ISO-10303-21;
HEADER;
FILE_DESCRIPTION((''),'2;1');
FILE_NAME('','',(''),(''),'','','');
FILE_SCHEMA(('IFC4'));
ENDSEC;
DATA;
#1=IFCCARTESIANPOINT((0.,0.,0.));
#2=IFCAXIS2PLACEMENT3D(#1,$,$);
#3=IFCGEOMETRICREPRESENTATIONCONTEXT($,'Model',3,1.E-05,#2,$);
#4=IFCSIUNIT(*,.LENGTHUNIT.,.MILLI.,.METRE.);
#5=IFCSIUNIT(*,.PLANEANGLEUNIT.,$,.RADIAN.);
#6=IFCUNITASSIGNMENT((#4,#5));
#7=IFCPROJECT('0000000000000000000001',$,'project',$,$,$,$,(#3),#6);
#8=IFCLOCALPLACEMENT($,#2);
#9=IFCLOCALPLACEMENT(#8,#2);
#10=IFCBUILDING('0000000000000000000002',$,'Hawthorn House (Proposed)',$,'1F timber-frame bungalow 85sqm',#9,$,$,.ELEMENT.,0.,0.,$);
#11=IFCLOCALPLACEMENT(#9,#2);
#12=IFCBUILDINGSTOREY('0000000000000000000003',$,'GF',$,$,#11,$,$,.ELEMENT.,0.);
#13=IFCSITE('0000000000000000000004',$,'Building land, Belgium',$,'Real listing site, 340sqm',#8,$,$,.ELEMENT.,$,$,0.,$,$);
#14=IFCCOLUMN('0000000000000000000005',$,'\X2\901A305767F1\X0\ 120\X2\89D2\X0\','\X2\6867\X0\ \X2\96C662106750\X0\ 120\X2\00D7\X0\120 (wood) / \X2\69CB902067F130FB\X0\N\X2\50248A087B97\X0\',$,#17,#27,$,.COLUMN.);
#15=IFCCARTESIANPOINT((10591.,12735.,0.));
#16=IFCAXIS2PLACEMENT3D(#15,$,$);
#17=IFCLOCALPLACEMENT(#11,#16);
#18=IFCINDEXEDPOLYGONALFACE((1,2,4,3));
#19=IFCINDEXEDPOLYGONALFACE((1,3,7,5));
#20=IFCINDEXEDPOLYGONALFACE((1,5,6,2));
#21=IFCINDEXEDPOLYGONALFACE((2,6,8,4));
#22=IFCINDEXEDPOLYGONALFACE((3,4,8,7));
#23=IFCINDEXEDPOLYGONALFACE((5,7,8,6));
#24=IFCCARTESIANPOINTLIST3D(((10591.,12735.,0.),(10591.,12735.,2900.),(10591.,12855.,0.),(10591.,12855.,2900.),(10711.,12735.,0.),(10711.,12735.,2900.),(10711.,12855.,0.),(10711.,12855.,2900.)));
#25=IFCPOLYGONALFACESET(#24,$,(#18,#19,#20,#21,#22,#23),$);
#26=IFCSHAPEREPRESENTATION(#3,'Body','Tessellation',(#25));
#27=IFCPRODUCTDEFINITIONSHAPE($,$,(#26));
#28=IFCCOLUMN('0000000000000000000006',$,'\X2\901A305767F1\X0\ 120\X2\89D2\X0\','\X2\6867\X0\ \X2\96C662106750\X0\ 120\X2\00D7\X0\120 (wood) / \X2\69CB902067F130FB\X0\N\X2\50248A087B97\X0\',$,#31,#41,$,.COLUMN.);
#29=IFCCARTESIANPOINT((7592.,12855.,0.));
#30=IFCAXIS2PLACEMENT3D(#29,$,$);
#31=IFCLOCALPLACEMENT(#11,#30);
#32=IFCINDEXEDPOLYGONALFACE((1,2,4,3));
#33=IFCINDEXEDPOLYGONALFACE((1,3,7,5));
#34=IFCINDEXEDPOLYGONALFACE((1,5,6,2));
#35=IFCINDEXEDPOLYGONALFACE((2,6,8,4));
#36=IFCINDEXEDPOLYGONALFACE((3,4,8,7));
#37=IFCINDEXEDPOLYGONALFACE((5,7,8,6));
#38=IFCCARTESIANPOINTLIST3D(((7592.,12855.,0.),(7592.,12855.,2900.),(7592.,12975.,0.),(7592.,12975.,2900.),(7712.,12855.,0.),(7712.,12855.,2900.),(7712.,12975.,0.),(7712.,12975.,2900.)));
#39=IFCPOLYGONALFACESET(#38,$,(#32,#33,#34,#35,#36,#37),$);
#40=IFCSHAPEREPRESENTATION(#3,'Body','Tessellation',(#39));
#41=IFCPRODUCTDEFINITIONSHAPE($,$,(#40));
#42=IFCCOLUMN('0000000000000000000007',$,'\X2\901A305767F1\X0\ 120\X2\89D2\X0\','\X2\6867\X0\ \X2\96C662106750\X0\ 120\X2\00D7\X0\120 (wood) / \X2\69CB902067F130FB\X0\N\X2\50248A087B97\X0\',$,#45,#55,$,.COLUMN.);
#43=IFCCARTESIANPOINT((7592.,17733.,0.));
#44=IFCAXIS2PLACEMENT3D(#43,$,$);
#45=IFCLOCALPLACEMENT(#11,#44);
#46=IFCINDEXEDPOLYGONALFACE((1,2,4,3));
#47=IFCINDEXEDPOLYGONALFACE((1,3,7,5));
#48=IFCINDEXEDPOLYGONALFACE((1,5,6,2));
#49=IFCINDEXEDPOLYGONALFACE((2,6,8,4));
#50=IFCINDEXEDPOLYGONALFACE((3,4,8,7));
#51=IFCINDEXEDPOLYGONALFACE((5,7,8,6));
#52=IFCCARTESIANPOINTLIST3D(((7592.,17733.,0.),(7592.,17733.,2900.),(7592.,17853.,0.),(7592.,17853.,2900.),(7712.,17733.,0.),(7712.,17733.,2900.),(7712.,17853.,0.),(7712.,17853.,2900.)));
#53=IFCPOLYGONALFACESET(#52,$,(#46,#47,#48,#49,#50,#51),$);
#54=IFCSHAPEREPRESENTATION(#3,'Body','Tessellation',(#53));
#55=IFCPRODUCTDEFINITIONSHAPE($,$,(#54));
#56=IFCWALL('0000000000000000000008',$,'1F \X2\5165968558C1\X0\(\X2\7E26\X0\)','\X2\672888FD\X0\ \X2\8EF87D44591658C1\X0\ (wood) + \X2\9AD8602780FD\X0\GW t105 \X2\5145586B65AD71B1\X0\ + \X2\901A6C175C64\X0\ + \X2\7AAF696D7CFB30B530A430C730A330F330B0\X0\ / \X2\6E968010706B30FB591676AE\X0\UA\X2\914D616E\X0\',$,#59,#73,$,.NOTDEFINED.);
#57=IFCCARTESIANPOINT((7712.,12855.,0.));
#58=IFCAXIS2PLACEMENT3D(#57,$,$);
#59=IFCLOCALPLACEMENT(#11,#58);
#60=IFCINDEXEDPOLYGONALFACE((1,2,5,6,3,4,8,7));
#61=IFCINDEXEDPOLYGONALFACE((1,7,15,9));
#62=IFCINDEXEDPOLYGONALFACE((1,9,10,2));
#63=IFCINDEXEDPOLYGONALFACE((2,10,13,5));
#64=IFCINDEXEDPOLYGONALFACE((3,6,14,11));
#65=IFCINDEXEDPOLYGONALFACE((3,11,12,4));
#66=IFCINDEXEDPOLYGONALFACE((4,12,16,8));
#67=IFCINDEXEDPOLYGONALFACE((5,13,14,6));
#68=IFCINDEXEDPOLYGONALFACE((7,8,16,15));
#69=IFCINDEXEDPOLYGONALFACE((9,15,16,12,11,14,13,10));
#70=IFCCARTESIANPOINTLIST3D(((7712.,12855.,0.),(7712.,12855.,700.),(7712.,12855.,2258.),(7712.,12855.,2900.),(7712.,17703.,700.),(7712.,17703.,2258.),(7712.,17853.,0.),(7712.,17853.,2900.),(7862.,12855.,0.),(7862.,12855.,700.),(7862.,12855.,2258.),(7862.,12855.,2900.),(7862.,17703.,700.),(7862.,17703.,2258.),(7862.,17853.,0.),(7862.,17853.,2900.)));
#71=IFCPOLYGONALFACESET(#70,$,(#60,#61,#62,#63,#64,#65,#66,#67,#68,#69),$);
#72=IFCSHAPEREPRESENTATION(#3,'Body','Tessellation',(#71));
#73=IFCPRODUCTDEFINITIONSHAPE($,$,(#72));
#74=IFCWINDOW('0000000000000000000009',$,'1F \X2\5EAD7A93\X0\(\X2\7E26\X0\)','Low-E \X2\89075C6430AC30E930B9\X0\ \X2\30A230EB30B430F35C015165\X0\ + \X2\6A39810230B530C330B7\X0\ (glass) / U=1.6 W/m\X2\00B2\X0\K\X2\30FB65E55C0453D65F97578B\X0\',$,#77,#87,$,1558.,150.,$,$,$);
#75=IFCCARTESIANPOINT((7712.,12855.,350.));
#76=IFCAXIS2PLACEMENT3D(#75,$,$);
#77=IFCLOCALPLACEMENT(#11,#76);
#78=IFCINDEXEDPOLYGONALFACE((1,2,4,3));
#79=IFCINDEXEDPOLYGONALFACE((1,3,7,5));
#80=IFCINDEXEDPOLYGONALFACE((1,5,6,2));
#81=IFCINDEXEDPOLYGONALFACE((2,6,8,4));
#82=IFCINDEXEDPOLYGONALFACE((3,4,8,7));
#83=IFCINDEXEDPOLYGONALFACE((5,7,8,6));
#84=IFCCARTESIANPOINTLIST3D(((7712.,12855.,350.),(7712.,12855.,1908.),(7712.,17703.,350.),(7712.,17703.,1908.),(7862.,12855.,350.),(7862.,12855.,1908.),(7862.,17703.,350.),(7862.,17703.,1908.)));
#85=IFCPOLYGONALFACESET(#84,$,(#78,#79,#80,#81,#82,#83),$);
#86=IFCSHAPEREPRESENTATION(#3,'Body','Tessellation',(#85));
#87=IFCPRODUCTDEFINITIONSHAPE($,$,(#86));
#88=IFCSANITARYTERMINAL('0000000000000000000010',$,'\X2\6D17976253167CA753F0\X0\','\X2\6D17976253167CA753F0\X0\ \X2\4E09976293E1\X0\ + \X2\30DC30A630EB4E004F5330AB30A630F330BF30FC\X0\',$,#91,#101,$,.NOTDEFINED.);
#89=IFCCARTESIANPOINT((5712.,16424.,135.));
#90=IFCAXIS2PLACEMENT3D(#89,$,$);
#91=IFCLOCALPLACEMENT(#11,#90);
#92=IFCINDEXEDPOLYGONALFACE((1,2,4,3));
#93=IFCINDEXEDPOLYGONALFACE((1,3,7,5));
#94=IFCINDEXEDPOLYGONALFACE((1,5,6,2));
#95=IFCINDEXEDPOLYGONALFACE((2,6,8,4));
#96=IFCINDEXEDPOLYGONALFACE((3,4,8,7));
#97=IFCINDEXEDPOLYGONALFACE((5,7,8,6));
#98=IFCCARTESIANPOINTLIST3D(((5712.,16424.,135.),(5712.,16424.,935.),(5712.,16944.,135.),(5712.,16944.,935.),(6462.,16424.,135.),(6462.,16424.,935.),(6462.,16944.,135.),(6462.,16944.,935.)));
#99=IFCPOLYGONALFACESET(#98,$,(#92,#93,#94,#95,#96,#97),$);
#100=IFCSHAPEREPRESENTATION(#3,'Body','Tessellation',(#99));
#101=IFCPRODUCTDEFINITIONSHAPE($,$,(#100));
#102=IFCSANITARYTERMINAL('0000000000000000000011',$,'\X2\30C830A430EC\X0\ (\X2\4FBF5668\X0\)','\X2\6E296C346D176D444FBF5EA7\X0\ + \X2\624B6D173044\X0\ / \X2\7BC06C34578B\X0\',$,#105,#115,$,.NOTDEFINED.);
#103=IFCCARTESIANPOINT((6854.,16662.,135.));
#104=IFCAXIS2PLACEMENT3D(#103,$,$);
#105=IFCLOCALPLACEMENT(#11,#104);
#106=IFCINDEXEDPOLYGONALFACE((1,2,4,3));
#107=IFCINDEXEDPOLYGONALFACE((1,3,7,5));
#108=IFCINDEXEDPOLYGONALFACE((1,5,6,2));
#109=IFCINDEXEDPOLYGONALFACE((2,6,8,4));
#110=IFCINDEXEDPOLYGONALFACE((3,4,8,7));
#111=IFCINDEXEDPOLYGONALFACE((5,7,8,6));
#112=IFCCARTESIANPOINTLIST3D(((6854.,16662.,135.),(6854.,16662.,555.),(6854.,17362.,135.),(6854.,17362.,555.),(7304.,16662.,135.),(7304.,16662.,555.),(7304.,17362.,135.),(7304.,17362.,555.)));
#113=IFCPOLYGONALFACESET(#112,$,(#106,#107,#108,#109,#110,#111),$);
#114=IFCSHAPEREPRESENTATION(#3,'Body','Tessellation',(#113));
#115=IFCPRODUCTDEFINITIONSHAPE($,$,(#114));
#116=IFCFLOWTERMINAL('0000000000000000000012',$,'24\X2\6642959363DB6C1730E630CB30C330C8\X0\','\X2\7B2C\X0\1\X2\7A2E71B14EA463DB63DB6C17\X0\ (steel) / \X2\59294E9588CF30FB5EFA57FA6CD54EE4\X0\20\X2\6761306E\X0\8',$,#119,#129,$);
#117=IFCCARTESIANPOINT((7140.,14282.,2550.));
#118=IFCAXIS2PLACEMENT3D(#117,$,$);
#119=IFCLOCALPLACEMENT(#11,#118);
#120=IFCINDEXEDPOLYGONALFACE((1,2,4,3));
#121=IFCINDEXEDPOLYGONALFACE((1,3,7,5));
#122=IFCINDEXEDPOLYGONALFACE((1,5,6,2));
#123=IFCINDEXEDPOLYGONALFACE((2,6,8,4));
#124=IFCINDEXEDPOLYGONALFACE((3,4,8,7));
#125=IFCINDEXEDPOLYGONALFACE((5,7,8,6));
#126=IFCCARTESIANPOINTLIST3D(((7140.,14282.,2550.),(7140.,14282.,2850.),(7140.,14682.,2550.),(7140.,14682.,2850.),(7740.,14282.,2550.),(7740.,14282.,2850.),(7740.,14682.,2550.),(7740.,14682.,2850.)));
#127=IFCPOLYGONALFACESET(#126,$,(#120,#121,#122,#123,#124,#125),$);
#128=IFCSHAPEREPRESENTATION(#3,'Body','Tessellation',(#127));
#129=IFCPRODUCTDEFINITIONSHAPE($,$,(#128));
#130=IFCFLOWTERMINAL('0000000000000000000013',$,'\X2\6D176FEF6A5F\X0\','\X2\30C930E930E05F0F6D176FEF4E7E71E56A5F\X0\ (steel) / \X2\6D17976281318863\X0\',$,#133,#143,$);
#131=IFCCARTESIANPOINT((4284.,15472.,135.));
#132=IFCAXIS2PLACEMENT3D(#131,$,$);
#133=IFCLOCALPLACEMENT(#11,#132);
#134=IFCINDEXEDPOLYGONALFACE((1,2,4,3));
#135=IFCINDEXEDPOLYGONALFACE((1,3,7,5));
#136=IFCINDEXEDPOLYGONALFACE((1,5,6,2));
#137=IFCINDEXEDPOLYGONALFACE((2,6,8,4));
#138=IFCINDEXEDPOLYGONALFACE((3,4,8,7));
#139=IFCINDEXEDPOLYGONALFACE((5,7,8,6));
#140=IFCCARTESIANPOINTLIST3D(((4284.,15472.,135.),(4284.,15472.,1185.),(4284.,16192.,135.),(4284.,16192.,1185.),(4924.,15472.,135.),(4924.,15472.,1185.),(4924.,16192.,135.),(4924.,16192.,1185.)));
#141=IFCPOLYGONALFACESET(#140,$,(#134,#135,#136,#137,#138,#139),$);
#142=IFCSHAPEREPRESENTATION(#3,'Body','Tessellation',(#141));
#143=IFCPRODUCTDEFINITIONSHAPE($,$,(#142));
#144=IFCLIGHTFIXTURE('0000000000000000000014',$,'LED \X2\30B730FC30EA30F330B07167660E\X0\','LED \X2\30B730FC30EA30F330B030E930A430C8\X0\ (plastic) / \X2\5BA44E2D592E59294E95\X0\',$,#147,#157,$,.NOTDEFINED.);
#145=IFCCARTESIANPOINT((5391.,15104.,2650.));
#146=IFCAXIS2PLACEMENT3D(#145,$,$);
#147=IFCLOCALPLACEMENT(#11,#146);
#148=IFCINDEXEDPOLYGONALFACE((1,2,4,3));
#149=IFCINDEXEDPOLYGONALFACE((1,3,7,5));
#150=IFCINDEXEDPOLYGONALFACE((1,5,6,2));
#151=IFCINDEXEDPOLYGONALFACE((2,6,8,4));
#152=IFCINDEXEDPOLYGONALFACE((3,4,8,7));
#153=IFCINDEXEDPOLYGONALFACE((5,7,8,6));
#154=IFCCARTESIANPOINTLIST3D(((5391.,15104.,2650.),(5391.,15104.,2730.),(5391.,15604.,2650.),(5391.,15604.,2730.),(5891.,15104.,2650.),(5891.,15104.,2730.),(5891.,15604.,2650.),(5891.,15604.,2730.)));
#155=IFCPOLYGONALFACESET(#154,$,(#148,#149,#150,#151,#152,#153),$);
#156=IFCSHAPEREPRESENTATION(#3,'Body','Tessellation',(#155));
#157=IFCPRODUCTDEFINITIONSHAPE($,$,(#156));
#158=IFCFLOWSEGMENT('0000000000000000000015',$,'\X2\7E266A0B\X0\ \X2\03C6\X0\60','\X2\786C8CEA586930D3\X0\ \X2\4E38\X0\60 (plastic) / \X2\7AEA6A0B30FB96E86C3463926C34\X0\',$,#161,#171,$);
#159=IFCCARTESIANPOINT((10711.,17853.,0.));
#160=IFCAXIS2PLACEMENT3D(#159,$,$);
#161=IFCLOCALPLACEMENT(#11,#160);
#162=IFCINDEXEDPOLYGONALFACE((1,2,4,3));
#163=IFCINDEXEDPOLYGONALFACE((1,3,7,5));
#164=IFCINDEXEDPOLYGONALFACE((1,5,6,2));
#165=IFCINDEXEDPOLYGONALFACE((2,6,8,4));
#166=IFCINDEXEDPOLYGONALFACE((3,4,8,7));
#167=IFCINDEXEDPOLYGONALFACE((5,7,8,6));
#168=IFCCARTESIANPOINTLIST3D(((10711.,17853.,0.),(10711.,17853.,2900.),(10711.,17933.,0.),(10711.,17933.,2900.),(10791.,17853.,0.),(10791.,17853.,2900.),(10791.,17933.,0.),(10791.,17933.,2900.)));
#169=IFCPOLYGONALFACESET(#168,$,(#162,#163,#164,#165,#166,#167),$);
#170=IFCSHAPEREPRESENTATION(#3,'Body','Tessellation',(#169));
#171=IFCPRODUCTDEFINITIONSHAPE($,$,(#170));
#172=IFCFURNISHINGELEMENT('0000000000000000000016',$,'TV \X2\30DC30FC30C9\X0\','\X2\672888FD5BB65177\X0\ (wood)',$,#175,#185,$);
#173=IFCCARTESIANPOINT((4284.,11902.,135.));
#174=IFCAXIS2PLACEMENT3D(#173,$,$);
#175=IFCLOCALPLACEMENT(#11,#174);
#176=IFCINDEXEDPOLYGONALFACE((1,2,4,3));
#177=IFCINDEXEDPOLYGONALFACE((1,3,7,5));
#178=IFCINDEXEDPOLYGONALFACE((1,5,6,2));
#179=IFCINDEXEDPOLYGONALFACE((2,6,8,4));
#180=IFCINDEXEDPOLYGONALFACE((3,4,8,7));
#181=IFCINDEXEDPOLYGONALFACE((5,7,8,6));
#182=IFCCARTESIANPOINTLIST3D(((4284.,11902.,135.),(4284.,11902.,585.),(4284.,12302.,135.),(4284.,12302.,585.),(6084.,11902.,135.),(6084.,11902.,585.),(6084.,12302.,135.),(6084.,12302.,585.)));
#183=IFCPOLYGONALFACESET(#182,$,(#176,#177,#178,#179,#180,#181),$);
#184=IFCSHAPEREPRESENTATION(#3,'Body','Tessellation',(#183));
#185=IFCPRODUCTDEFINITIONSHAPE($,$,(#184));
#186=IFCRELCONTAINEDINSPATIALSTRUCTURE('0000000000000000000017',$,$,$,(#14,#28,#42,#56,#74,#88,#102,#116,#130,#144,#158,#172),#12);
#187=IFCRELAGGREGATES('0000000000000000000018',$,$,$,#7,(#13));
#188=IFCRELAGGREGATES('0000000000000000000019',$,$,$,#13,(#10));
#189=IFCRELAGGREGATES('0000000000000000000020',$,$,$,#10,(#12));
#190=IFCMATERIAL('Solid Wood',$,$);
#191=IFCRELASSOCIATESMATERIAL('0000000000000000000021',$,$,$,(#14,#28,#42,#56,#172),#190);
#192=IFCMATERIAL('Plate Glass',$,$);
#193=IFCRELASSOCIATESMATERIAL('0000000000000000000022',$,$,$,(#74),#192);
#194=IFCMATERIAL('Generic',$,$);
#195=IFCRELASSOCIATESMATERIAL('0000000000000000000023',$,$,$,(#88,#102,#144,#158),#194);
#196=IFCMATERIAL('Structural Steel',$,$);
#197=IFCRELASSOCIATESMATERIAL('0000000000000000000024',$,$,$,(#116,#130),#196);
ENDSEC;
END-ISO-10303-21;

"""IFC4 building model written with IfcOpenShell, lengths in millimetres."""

from ifc_helpers import new_model, si_unit, frame, frame_2d, origin, place, context, project, spatial, rectangle, extrude, material, element, fill, save


model = new_model("IFC4")

# Units and contexts
model_context = context("Model", 3, precision=1e-05, world=origin())
ifc_project = project(units=[si_unit("LENGTHUNIT", "METRE", prefix="MILLI"), si_unit("PLANEANGLEUNIT", "RADIAN")], contexts=[model_context])

# Site, building, storey
site_placement = place(None, origin())
site = spatial("IfcSite", under=ifc_project, at=site_placement, Name="Building land, Belgium", ObjectType="Real listing site, 340sqm", CompositionType="ELEMENT", RefElevation=0.0)
building_placement = place(site_placement, origin())
building = spatial("IfcBuilding", under=site, at=building_placement, Name="Hawthorn House (Proposed)", ObjectType="1F timber-frame bungalow 85sqm", CompositionType="ELEMENT", ElevationOfRefHeight=0.0, ElevationOfTerrain=0.0)
storey_placement = place(building_placement, origin())
storey = spatial("IfcBuildingStorey", under=building, at=storey_placement, Name="GF", CompositionType="ELEMENT", Elevation=0.0)

# Columns
ifc_material_1 = material(Name="Solid Wood")
column_1_placement = place(storey_placement, frame((10591.0, 12735.0, 0.0)))
element("IfcColumn", 1, at=column_1_placement, inside=storey, material=ifc_material_1, Name="通し柱 120角", Description="桧 集成材 120×120 (wood) / 構造柱・N値計算", PredefinedType="COLUMN", context=model_context, shape_type="SweptSolid", body=[
    extrude(rectangle(XDim=120.0, YDim=120.0, at=frame_2d((60.0, 60.0))), frame((10591.0, 12735.0, 0.0)), (0.0, 0.0, 1.0), 2900.0),
])
column_2_placement = place(storey_placement, frame((7592.0, 12855.0, 0.0)))
element("IfcColumn", 2, at=column_2_placement, inside=storey, material=ifc_material_1, Name="通し柱 120角", Description="桧 集成材 120×120 (wood) / 構造柱・N値計算", PredefinedType="COLUMN", context=model_context, shape_type="SweptSolid", body=[
    extrude(rectangle(XDim=120.0, YDim=120.0, at=frame_2d((60.0, 60.0))), frame((7592.0, 12855.0, 0.0)), (0.0, 0.0, 1.0), 2900.0),
])
column_3_placement = place(storey_placement, frame((7592.0, 17733.0, 0.0)))
element("IfcColumn", 3, at=column_3_placement, inside=storey, material=ifc_material_1, Name="通し柱 120角", Description="桧 集成材 120×120 (wood) / 構造柱・N値計算", PredefinedType="COLUMN", context=model_context, shape_type="SweptSolid", body=[
    extrude(rectangle(XDim=120.0, YDim=120.0, at=frame_2d((60.0, 60.0))), frame((7592.0, 17733.0, 0.0)), (0.0, 0.0, 1.0), 2900.0),
])

# Wall, opening, window
wall_1_placement = place(storey_placement, frame((7712.0, 12855.0, 0.0)))
wall_1 = element("IfcWall", 4, at=wall_1_placement, inside=storey, material=ifc_material_1, Name="1F 入隅壁(縦)", Description="木製 軸組外壁 (wood) + 高性能GW t105 充填断熱 + 通気層 + 窯業系サイディング / 準耐火・外皮UA配慮", PredefinedType="NOTDEFINED", context=model_context, shape_type="SweptSolid", body=[
    extrude(rectangle(XDim=150.0, YDim=4998.0, at=frame_2d((75.0, 2499.0))), frame((7712.0, 12855.0, 0.0)), (0.0, 0.0, 1.0), 2900.0),
])
opening_placement = place(storey_placement, frame((7712.0, 12855.0, 350.0)))
opening = element("IfcOpeningElement", 5, at=opening_placement, cuts=wall_1, PredefinedType="NOTDEFINED", context=model_context, shape_type="SweptSolid", body=[
    extrude(rectangle(XDim=150.0, YDim=4848.0, at=frame_2d((75.0, 2424.0))), frame((7712.0, 12855.0, 350.0)), (0.0, 0.0, 1.0), 1558.0),
])
ifc_material_2 = material(Name="Plate Glass")
window_placement = place(storey_placement, frame((7712.0, 12855.0, 350.0)))
window = element("IfcWindow", 6, at=window_placement, inside=storey, material=ifc_material_2, Name="1F 庭窓(縦)", Description="Low-E 複層ガラス アルゴン封入 + 樹脂サッシ (glass) / U=1.6 W/m²K・日射取得型", OverallHeight=1558.0, OverallWidth=150.0, context=model_context, shape_type="SweptSolid", body=[
    extrude(rectangle(XDim=150.0, YDim=4848.0, at=frame_2d((75.0, 2424.0))), frame((7712.0, 12855.0, 350.0)), (0.0, 0.0, 1.0), 1558.0),
])
fill(opening, window)

# Sanitary terminals
ifc_material_3 = material(Name="Generic")
sanitary_terminal_1_placement = place(storey_placement, frame((5712.0, 16424.0, 135.0)))
element("IfcSanitaryTerminal", 7, at=sanitary_terminal_1_placement, inside=storey, material=ifc_material_3, Name="洗面化粧台", Description="洗面化粧台 三面鏡 + ボウル一体カウンター", PredefinedType="NOTDEFINED", context=model_context, shape_type="SweptSolid", body=[
    extrude(rectangle(XDim=750.0, YDim=520.0, at=frame_2d((375.0, 260.0))), frame((5712.0, 16424.0, 135.0)), (0.0, 0.0, 1.0), 800.0),
])
sanitary_terminal_2_placement = place(storey_placement, frame((6854.0, 16662.0, 135.0)))
element("IfcSanitaryTerminal", 8, at=sanitary_terminal_2_placement, inside=storey, material=ifc_material_3, Name="トイレ (便器)", Description="温水洗浄便座 + 手洗い / 節水型", PredefinedType="NOTDEFINED", context=model_context, shape_type="SweptSolid", body=[
    extrude(rectangle(XDim=450.0, YDim=700.0, at=frame_2d((225.0, 350.0))), frame((6854.0, 16662.0, 135.0)), (0.0, 0.0, 1.0), 420.0),
])

# Flow terminals
ifc_material_4 = material(Name="Structural Steel")
flow_terminal_1_placement = place(storey_placement, frame((7140.0, 14282.0, 2550.0)))
element("IfcFlowTerminal", 9, at=flow_terminal_1_placement, inside=storey, material=ifc_material_4, Name="24時間換気ユニット", Description="第1種熱交換換気 (steel) / 天井裏・建基法令20条の8", context=model_context, shape_type="SweptSolid", body=[
    extrude(rectangle(XDim=600.0, YDim=400.0, at=frame_2d((300.0, 200.0))), frame((7140.0, 14282.0, 2550.0)), (0.0, 0.0, 1.0), 300.0),
])
flow_terminal_2_placement = place(storey_placement, frame((4284.0, 15472.0, 135.0)))
element("IfcFlowTerminal", 10, at=flow_terminal_2_placement, inside=storey, material=ifc_material_4, Name="洗濯機", Description="ドラム式洗濯乾燥機 (steel) / 洗面脱衣", context=model_context, shape_type="SweptSolid", body=[
    extrude(rectangle(XDim=640.0, YDim=720.0, at=frame_2d((320.0, 360.0))), frame((4284.0, 15472.0, 135.0)), (0.0, 0.0, 1.0), 1050.0),
])

# Light fixture
light_fixture_placement = place(storey_placement, frame((5391.0, 15104.0, 2650.0)))
element("IfcLightFixture", 11, at=light_fixture_placement, inside=storey, material=ifc_material_3, Name="LED シーリング照明", Description="LED シーリングライト (plastic) / 室中央天井", PredefinedType="NOTDEFINED", context=model_context, shape_type="SweptSolid", body=[
    extrude(rectangle(XDim=500.0, YDim=500.0, at=frame_2d((250.0, 250.0))), frame((5391.0, 15104.0, 2650.0)), (0.0, 0.0, 1.0), 80.0),
])

# Flow segment
flow_segment_placement = place(storey_placement, frame((10711.0, 17853.0, 0.0)))
element("IfcFlowSegment", 12, at=flow_segment_placement, inside=storey, material=ifc_material_3, Name="縦樋 φ60", Description="硬質塩ビ 丸60 (plastic) / 竪樋・雨水排水", context=model_context, shape_type="SweptSolid", body=[
    extrude(rectangle(XDim=80.0, YDim=80.0, at=frame_2d((40.0, 40.0))), frame((10711.0, 17853.0, 0.0)), (0.0, 0.0, 1.0), 2900.0),
])

# Furnishing element
furnishing_placement = place(storey_placement, frame((4284.0, 11902.0, 135.0)))
element("IfcFurnishingElement", 13, at=furnishing_placement, inside=storey, material=ifc_material_1, Name="TV ボード", Description="木製家具 (wood)", context=model_context, shape_type="SweptSolid", body=[
    extrude(rectangle(XDim=1800.0, YDim=400.0, at=frame_2d((900.0, 200.0))), frame((4284.0, 11902.0, 135.0)), (0.0, 0.0, 1.0), 450.0),
])

save(model, "model.ifc")
